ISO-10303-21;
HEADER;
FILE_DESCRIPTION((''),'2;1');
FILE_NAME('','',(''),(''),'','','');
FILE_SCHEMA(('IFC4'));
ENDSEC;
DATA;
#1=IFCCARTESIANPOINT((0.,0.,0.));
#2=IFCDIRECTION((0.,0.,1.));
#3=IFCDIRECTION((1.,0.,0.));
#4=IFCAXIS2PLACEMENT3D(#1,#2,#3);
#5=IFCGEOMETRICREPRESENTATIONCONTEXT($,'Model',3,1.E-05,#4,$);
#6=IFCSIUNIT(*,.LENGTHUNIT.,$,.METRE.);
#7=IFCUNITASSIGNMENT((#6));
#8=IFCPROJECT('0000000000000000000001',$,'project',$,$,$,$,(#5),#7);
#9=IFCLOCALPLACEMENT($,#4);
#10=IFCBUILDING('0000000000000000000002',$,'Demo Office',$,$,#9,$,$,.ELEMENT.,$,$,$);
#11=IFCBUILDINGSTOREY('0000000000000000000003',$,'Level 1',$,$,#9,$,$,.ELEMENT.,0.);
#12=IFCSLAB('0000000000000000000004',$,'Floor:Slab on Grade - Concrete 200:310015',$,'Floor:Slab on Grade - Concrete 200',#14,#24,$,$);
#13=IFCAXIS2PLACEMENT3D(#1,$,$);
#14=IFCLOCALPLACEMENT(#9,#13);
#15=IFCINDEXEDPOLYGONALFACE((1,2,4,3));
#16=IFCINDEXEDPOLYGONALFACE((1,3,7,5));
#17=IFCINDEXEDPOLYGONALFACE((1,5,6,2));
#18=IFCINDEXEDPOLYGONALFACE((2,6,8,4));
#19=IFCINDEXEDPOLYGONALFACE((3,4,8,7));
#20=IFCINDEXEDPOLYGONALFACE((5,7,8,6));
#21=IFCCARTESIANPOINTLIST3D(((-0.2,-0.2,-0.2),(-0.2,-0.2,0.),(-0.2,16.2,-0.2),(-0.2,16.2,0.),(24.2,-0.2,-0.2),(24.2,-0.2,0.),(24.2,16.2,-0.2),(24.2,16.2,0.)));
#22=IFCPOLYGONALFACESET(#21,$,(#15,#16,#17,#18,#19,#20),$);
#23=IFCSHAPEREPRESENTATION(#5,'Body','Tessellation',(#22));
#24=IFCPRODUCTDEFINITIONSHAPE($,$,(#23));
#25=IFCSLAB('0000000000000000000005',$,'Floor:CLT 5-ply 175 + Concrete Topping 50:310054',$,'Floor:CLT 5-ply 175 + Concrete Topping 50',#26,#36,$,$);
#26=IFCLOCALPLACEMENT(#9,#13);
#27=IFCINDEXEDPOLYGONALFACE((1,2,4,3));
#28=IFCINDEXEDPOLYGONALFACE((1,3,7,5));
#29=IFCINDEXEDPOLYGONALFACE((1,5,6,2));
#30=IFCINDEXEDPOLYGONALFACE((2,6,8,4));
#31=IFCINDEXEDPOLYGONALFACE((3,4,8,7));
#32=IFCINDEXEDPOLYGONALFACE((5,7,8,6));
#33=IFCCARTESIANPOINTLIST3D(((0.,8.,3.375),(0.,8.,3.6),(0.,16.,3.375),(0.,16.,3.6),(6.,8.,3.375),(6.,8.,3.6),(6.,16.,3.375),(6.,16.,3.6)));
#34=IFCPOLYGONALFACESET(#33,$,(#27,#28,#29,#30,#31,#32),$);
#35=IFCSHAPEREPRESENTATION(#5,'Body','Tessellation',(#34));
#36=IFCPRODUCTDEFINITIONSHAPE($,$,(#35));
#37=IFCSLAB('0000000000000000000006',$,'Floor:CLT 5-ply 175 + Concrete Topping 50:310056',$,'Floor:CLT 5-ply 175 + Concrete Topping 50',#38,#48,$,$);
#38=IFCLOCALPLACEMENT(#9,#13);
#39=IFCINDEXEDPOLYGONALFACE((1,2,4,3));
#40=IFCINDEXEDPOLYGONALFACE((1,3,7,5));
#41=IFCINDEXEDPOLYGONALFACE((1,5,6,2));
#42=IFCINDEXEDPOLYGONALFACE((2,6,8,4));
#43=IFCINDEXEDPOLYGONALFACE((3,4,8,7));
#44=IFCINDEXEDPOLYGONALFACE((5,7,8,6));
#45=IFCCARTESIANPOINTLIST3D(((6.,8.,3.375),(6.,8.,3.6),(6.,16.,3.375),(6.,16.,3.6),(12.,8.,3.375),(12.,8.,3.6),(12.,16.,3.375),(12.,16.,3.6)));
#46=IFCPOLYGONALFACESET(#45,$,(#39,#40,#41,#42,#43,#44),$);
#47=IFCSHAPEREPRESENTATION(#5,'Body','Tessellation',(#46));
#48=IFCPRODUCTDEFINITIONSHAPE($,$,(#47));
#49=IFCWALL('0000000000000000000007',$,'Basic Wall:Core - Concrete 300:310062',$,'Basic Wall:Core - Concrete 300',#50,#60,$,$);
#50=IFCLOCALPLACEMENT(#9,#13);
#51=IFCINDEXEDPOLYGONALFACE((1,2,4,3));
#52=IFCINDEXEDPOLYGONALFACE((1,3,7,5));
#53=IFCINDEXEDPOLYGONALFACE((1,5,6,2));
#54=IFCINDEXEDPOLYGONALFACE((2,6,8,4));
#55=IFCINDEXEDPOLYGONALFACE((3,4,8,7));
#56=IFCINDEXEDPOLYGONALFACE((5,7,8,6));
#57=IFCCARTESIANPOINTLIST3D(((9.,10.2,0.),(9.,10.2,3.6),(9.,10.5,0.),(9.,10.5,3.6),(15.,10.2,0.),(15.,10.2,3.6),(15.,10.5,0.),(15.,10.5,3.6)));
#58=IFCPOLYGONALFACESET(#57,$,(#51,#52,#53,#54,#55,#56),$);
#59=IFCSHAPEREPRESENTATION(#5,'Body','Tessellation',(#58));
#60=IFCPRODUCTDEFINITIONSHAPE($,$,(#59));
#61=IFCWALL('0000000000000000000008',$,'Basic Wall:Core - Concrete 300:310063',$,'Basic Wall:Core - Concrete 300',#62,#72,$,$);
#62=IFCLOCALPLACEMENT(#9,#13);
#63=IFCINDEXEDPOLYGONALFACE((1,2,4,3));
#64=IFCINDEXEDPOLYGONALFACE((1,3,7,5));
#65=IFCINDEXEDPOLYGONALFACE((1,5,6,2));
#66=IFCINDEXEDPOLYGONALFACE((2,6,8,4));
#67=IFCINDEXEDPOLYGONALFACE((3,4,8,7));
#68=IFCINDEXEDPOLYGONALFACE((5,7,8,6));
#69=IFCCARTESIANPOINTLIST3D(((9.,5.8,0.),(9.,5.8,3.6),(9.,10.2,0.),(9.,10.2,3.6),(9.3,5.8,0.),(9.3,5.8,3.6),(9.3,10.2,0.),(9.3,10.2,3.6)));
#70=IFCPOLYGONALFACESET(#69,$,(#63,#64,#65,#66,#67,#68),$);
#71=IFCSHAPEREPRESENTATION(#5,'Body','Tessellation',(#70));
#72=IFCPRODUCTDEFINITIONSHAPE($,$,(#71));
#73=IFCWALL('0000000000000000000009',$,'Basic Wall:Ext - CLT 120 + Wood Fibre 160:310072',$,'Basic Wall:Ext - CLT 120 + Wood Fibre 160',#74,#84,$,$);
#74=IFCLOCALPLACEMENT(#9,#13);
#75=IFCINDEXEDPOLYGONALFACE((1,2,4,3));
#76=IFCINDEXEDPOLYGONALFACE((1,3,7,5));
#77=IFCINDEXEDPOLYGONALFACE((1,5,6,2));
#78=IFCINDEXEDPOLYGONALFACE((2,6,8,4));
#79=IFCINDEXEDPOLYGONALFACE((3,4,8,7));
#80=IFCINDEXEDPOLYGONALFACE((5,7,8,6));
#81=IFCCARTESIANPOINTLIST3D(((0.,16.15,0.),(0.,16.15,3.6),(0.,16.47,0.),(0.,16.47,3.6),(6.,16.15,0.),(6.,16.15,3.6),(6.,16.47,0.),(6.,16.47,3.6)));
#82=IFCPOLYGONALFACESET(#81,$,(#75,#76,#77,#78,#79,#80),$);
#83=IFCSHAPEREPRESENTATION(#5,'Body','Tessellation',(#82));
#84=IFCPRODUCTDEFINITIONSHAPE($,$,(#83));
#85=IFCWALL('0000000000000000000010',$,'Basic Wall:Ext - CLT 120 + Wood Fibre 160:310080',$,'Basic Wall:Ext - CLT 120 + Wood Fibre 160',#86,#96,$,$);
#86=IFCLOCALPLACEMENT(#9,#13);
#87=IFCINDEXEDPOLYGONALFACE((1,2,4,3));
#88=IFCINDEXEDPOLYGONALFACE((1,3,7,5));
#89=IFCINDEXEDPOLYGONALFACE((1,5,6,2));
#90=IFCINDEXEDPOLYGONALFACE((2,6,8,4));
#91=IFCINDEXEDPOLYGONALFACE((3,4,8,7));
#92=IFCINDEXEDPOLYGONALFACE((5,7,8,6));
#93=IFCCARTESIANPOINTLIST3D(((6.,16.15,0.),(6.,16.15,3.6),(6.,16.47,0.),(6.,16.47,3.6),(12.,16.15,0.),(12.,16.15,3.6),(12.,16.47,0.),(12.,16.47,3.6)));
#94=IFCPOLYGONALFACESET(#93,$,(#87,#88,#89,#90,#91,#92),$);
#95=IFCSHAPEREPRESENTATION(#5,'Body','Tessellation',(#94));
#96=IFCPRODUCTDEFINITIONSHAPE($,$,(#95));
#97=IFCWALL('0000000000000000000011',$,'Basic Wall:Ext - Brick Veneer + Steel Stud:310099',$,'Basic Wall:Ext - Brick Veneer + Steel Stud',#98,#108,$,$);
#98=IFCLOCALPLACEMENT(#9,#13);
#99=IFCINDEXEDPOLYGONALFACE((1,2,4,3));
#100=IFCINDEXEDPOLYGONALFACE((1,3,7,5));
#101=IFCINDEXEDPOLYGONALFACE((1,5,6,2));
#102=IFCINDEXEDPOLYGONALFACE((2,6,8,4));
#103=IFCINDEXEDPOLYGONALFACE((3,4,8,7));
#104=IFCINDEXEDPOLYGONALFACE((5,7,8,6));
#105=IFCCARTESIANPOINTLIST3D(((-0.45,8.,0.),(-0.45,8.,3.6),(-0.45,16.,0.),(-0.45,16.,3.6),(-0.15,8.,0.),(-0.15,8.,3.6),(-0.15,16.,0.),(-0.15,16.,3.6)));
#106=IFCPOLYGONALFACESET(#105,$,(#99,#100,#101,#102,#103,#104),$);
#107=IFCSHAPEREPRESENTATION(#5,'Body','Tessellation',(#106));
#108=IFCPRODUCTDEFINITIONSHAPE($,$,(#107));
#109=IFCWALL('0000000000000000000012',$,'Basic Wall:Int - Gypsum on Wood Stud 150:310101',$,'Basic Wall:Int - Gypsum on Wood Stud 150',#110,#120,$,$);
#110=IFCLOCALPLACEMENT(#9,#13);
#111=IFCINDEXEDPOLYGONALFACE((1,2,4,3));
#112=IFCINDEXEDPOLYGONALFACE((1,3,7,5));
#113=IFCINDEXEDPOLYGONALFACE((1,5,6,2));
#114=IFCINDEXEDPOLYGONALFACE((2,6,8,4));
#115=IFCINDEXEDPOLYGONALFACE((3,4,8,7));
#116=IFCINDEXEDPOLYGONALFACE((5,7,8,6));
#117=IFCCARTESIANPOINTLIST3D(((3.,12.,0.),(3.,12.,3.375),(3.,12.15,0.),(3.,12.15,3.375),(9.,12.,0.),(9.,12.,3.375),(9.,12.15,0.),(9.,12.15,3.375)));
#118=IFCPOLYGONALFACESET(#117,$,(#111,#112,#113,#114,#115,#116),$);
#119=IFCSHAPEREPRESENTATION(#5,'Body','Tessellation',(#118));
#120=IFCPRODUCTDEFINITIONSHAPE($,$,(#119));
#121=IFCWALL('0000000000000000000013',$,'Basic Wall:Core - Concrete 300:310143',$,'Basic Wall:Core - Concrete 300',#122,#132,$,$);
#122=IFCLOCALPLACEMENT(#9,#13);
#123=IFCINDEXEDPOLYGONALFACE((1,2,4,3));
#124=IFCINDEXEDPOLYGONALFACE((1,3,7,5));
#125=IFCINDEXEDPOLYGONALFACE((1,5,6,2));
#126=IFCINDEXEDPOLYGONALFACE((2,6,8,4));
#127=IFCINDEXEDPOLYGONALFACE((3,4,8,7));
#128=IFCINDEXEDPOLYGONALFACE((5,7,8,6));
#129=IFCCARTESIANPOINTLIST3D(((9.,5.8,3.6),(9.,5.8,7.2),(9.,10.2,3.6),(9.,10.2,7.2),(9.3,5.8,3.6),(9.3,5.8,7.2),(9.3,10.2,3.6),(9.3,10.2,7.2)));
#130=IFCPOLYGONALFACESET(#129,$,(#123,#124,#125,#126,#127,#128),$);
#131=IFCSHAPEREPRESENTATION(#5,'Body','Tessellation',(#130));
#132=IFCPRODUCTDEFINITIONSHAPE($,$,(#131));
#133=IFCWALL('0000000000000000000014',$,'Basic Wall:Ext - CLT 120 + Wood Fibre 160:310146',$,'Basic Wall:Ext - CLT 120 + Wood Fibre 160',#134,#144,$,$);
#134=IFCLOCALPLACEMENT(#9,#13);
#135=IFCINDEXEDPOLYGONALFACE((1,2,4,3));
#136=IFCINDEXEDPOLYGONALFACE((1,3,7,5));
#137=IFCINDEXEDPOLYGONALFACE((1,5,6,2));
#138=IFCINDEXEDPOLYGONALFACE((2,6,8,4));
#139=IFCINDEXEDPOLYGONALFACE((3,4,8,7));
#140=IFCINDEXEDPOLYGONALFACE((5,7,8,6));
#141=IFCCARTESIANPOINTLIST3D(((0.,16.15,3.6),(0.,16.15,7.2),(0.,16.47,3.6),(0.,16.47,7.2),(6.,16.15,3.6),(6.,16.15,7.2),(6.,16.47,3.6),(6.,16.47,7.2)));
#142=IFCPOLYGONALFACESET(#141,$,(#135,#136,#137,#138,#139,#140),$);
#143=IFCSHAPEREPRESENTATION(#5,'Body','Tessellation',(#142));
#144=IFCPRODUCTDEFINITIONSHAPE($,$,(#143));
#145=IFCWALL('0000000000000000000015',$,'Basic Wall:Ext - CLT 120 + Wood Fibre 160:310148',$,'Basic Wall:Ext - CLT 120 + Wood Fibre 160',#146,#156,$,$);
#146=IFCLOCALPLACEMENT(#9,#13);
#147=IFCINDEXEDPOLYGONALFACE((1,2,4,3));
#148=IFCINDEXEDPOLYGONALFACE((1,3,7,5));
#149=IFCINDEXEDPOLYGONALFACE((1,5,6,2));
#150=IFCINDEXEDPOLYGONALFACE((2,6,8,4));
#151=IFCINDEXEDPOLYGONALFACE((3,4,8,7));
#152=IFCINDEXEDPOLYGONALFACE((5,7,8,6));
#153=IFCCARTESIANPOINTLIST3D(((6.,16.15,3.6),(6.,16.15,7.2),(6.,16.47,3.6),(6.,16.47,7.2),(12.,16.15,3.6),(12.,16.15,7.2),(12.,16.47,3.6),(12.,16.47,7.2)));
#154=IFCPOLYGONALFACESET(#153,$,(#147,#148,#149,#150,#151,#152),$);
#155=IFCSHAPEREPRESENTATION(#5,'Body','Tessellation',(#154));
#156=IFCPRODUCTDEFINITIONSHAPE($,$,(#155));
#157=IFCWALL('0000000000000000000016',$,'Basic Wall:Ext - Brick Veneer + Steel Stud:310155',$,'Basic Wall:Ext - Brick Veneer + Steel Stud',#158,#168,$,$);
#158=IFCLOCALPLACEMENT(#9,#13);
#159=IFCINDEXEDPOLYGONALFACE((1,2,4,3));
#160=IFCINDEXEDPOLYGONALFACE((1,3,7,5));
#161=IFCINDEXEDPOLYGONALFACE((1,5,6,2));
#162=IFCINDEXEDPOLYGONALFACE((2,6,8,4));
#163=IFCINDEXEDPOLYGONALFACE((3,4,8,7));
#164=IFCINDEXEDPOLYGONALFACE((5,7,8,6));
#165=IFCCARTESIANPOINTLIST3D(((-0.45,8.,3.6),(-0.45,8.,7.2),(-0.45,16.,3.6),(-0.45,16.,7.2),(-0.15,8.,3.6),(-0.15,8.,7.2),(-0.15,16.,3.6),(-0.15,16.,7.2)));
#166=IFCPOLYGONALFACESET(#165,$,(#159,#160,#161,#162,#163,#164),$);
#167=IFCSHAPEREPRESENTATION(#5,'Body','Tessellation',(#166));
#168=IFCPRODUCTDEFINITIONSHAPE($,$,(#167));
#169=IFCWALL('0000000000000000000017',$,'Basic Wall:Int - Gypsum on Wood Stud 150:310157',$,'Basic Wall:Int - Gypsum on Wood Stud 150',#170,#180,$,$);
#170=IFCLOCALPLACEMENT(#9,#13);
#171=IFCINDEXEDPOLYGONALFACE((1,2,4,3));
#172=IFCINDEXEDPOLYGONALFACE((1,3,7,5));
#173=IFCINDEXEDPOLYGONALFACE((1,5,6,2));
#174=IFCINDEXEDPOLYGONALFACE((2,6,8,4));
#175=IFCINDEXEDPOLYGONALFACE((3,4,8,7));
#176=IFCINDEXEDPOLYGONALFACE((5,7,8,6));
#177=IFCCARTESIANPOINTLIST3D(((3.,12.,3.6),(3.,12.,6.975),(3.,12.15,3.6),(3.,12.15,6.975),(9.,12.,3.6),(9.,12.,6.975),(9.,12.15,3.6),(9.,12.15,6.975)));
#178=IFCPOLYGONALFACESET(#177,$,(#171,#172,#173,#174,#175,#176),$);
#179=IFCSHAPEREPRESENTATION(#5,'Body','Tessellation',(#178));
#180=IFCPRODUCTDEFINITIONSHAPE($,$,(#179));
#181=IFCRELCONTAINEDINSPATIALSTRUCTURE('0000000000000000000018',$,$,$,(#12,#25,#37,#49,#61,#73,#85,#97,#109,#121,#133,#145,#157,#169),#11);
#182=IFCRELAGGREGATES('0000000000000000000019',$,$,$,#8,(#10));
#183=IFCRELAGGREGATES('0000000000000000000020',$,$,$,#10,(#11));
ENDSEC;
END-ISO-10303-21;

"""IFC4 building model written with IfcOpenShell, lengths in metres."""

from ifc_helpers import new_model, si_unit, frame, origin_with_axes, origin_2d, place, context, project, spatial, rectangle, extrude, element, save


model = new_model("IFC4")

# Units and contexts
model_context = context("Model", 3, precision=1e-05, world=origin_with_axes())
ifc_project = project(units=[si_unit("LENGTHUNIT", "METRE")], contexts=[model_context])

# Building, storey
placement = place(None, origin_with_axes())
building = spatial("IfcBuilding", under=ifc_project, at=placement, Name="Demo Office", CompositionType="ELEMENT")
storey = spatial("IfcBuildingStorey", under=building, at=placement, Name="Level 1", CompositionType="ELEMENT", Elevation=0.0)

# Slabs
slab_placement = place(placement, frame((12.0, 8.0, -0.2)))
element("IfcSlab", 1, at=slab_placement, inside=storey, Name="Floor:Slab on Grade - Concrete 200:310015", ObjectType="Floor:Slab on Grade - Concrete 200", context=model_context, shape_type="SweptSolid", body=[
    extrude(rectangle(XDim=24.4, YDim=16.4, at=origin_2d()), origin_with_axes(), (0.0, 0.0, 1.0), 0.2),
])
for number, where, name in (
    (2, (3.0, 12.0, 3.375), "Floor:CLT 5-ply 175 + Concrete Topping 50:310054"),
    (3, (9.0, 12.0, 3.375), "Floor:CLT 5-ply 175 + Concrete Topping 50:310056"),
):
    element("IfcSlab", number, at=place(placement, frame(where)), inside=storey, Name=name, ObjectType="Floor:CLT 5-ply 175 + Concrete Topping 50", context=model_context, shape_type="SweptSolid", body=[
        extrude(rectangle(XDim=6.0, YDim=8.0, at=origin_2d()), origin_with_axes(), (0.0, 0.0, 1.0), 0.225),
    ])

# Walls
wall_1_placement = place(placement, frame((12.0, 10.35, 0.0)))
element("IfcWall", 4, at=wall_1_placement, inside=storey, Name="Basic Wall:Core - Concrete 300:310062", ObjectType="Basic Wall:Core - Concrete 300", context=model_context, shape_type="SweptSolid", body=[
    extrude(rectangle(XDim=6.0, YDim=0.3, at=origin_2d()), origin_with_axes(), (0.0, 0.0, 1.0), 3.6),
])
wall_2_placement = place(placement, frame((9.15, 8.0, 0.0)))
element("IfcWall", 5, at=wall_2_placement, inside=storey, Name="Basic Wall:Core - Concrete 300:310063", ObjectType="Basic Wall:Core - Concrete 300", context=model_context, shape_type="SweptSolid", body=[
    extrude(rectangle(XDim=0.3, YDim=4.4, at=origin_2d()), origin_with_axes(), (0.0, 0.0, 1.0), 3.6),
])
for number, where, name in (
    (6, (3.0, 16.31, 0.0), "Basic Wall:Ext - CLT 120 + Wood Fibre 160:310072"),
    (7, (9.0, 16.31, 0.0), "Basic Wall:Ext - CLT 120 + Wood Fibre 160:310080"),
):
    element("IfcWall", number, at=place(placement, frame(where)), inside=storey, Name=name, ObjectType="Basic Wall:Ext - CLT 120 + Wood Fibre 160", context=model_context, shape_type="SweptSolid", body=[
        extrude(rectangle(XDim=6.0, YDim=0.32, at=origin_2d()), origin_with_axes(), (0.0, 0.0, 1.0), 3.6),
    ])
wall_3_placement = place(placement, frame((-0.3, 12.0, 0.0)))
element("IfcWall", 8, at=wall_3_placement, inside=storey, Name="Basic Wall:Ext - Brick Veneer + Steel Stud:310099", ObjectType="Basic Wall:Ext - Brick Veneer + Steel Stud", context=model_context, shape_type="SweptSolid", body=[
    extrude(rectangle(XDim=0.3, YDim=8.0, at=origin_2d()), origin_with_axes(), (0.0, 0.0, 1.0), 3.6),
])
wall_4_placement = place(placement, frame((6.0, 12.075, 0.0)))
element("IfcWall", 9, at=wall_4_placement, inside=storey, Name="Basic Wall:Int - Gypsum on Wood Stud 150:310101", ObjectType="Basic Wall:Int - Gypsum on Wood Stud 150", context=model_context, shape_type="SweptSolid", body=[
    extrude(rectangle(XDim=6.0, YDim=0.15, at=origin_2d()), origin_with_axes(), (0.0, 0.0, 1.0), 3.375),
])
wall_5_placement = place(placement, frame((9.15, 8.0, 3.6)))
element("IfcWall", 10, at=wall_5_placement, inside=storey, Name="Basic Wall:Core - Concrete 300:310143", ObjectType="Basic Wall:Core - Concrete 300", context=model_context, shape_type="SweptSolid", body=[
    extrude(rectangle(XDim=0.3, YDim=4.4, at=origin_2d()), origin_with_axes(), (0.0, 0.0, 1.0), 3.6),
])
for number, where, name in (
    (11, (3.0, 16.31, 3.6), "Basic Wall:Ext - CLT 120 + Wood Fibre 160:310146"),
    (12, (9.0, 16.31, 3.6), "Basic Wall:Ext - CLT 120 + Wood Fibre 160:310148"),
):
    element("IfcWall", number, at=place(placement, frame(where)), inside=storey, Name=name, ObjectType="Basic Wall:Ext - CLT 120 + Wood Fibre 160", context=model_context, shape_type="SweptSolid", body=[
        extrude(rectangle(XDim=6.0, YDim=0.32, at=origin_2d()), origin_with_axes(), (0.0, 0.0, 1.0), 3.6),
    ])
wall_6_placement = place(placement, frame((-0.3, 12.0, 3.6)))
element("IfcWall", 13, at=wall_6_placement, inside=storey, Name="Basic Wall:Ext - Brick Veneer + Steel Stud:310155", ObjectType="Basic Wall:Ext - Brick Veneer + Steel Stud", context=model_context, shape_type="SweptSolid", body=[
    extrude(rectangle(XDim=0.3, YDim=8.0, at=origin_2d()), origin_with_axes(), (0.0, 0.0, 1.0), 3.6),
])
wall_7_placement = place(placement, frame((6.0, 12.075, 3.6)))
element("IfcWall", 14, at=wall_7_placement, inside=storey, Name="Basic Wall:Int - Gypsum on Wood Stud 150:310157", ObjectType="Basic Wall:Int - Gypsum on Wood Stud 150", context=model_context, shape_type="SweptSolid", body=[
    extrude(rectangle(XDim=6.0, YDim=0.15, at=origin_2d()), origin_with_axes(), (0.0, 0.0, 1.0), 3.375),
])

save(model, "model.ifc")
